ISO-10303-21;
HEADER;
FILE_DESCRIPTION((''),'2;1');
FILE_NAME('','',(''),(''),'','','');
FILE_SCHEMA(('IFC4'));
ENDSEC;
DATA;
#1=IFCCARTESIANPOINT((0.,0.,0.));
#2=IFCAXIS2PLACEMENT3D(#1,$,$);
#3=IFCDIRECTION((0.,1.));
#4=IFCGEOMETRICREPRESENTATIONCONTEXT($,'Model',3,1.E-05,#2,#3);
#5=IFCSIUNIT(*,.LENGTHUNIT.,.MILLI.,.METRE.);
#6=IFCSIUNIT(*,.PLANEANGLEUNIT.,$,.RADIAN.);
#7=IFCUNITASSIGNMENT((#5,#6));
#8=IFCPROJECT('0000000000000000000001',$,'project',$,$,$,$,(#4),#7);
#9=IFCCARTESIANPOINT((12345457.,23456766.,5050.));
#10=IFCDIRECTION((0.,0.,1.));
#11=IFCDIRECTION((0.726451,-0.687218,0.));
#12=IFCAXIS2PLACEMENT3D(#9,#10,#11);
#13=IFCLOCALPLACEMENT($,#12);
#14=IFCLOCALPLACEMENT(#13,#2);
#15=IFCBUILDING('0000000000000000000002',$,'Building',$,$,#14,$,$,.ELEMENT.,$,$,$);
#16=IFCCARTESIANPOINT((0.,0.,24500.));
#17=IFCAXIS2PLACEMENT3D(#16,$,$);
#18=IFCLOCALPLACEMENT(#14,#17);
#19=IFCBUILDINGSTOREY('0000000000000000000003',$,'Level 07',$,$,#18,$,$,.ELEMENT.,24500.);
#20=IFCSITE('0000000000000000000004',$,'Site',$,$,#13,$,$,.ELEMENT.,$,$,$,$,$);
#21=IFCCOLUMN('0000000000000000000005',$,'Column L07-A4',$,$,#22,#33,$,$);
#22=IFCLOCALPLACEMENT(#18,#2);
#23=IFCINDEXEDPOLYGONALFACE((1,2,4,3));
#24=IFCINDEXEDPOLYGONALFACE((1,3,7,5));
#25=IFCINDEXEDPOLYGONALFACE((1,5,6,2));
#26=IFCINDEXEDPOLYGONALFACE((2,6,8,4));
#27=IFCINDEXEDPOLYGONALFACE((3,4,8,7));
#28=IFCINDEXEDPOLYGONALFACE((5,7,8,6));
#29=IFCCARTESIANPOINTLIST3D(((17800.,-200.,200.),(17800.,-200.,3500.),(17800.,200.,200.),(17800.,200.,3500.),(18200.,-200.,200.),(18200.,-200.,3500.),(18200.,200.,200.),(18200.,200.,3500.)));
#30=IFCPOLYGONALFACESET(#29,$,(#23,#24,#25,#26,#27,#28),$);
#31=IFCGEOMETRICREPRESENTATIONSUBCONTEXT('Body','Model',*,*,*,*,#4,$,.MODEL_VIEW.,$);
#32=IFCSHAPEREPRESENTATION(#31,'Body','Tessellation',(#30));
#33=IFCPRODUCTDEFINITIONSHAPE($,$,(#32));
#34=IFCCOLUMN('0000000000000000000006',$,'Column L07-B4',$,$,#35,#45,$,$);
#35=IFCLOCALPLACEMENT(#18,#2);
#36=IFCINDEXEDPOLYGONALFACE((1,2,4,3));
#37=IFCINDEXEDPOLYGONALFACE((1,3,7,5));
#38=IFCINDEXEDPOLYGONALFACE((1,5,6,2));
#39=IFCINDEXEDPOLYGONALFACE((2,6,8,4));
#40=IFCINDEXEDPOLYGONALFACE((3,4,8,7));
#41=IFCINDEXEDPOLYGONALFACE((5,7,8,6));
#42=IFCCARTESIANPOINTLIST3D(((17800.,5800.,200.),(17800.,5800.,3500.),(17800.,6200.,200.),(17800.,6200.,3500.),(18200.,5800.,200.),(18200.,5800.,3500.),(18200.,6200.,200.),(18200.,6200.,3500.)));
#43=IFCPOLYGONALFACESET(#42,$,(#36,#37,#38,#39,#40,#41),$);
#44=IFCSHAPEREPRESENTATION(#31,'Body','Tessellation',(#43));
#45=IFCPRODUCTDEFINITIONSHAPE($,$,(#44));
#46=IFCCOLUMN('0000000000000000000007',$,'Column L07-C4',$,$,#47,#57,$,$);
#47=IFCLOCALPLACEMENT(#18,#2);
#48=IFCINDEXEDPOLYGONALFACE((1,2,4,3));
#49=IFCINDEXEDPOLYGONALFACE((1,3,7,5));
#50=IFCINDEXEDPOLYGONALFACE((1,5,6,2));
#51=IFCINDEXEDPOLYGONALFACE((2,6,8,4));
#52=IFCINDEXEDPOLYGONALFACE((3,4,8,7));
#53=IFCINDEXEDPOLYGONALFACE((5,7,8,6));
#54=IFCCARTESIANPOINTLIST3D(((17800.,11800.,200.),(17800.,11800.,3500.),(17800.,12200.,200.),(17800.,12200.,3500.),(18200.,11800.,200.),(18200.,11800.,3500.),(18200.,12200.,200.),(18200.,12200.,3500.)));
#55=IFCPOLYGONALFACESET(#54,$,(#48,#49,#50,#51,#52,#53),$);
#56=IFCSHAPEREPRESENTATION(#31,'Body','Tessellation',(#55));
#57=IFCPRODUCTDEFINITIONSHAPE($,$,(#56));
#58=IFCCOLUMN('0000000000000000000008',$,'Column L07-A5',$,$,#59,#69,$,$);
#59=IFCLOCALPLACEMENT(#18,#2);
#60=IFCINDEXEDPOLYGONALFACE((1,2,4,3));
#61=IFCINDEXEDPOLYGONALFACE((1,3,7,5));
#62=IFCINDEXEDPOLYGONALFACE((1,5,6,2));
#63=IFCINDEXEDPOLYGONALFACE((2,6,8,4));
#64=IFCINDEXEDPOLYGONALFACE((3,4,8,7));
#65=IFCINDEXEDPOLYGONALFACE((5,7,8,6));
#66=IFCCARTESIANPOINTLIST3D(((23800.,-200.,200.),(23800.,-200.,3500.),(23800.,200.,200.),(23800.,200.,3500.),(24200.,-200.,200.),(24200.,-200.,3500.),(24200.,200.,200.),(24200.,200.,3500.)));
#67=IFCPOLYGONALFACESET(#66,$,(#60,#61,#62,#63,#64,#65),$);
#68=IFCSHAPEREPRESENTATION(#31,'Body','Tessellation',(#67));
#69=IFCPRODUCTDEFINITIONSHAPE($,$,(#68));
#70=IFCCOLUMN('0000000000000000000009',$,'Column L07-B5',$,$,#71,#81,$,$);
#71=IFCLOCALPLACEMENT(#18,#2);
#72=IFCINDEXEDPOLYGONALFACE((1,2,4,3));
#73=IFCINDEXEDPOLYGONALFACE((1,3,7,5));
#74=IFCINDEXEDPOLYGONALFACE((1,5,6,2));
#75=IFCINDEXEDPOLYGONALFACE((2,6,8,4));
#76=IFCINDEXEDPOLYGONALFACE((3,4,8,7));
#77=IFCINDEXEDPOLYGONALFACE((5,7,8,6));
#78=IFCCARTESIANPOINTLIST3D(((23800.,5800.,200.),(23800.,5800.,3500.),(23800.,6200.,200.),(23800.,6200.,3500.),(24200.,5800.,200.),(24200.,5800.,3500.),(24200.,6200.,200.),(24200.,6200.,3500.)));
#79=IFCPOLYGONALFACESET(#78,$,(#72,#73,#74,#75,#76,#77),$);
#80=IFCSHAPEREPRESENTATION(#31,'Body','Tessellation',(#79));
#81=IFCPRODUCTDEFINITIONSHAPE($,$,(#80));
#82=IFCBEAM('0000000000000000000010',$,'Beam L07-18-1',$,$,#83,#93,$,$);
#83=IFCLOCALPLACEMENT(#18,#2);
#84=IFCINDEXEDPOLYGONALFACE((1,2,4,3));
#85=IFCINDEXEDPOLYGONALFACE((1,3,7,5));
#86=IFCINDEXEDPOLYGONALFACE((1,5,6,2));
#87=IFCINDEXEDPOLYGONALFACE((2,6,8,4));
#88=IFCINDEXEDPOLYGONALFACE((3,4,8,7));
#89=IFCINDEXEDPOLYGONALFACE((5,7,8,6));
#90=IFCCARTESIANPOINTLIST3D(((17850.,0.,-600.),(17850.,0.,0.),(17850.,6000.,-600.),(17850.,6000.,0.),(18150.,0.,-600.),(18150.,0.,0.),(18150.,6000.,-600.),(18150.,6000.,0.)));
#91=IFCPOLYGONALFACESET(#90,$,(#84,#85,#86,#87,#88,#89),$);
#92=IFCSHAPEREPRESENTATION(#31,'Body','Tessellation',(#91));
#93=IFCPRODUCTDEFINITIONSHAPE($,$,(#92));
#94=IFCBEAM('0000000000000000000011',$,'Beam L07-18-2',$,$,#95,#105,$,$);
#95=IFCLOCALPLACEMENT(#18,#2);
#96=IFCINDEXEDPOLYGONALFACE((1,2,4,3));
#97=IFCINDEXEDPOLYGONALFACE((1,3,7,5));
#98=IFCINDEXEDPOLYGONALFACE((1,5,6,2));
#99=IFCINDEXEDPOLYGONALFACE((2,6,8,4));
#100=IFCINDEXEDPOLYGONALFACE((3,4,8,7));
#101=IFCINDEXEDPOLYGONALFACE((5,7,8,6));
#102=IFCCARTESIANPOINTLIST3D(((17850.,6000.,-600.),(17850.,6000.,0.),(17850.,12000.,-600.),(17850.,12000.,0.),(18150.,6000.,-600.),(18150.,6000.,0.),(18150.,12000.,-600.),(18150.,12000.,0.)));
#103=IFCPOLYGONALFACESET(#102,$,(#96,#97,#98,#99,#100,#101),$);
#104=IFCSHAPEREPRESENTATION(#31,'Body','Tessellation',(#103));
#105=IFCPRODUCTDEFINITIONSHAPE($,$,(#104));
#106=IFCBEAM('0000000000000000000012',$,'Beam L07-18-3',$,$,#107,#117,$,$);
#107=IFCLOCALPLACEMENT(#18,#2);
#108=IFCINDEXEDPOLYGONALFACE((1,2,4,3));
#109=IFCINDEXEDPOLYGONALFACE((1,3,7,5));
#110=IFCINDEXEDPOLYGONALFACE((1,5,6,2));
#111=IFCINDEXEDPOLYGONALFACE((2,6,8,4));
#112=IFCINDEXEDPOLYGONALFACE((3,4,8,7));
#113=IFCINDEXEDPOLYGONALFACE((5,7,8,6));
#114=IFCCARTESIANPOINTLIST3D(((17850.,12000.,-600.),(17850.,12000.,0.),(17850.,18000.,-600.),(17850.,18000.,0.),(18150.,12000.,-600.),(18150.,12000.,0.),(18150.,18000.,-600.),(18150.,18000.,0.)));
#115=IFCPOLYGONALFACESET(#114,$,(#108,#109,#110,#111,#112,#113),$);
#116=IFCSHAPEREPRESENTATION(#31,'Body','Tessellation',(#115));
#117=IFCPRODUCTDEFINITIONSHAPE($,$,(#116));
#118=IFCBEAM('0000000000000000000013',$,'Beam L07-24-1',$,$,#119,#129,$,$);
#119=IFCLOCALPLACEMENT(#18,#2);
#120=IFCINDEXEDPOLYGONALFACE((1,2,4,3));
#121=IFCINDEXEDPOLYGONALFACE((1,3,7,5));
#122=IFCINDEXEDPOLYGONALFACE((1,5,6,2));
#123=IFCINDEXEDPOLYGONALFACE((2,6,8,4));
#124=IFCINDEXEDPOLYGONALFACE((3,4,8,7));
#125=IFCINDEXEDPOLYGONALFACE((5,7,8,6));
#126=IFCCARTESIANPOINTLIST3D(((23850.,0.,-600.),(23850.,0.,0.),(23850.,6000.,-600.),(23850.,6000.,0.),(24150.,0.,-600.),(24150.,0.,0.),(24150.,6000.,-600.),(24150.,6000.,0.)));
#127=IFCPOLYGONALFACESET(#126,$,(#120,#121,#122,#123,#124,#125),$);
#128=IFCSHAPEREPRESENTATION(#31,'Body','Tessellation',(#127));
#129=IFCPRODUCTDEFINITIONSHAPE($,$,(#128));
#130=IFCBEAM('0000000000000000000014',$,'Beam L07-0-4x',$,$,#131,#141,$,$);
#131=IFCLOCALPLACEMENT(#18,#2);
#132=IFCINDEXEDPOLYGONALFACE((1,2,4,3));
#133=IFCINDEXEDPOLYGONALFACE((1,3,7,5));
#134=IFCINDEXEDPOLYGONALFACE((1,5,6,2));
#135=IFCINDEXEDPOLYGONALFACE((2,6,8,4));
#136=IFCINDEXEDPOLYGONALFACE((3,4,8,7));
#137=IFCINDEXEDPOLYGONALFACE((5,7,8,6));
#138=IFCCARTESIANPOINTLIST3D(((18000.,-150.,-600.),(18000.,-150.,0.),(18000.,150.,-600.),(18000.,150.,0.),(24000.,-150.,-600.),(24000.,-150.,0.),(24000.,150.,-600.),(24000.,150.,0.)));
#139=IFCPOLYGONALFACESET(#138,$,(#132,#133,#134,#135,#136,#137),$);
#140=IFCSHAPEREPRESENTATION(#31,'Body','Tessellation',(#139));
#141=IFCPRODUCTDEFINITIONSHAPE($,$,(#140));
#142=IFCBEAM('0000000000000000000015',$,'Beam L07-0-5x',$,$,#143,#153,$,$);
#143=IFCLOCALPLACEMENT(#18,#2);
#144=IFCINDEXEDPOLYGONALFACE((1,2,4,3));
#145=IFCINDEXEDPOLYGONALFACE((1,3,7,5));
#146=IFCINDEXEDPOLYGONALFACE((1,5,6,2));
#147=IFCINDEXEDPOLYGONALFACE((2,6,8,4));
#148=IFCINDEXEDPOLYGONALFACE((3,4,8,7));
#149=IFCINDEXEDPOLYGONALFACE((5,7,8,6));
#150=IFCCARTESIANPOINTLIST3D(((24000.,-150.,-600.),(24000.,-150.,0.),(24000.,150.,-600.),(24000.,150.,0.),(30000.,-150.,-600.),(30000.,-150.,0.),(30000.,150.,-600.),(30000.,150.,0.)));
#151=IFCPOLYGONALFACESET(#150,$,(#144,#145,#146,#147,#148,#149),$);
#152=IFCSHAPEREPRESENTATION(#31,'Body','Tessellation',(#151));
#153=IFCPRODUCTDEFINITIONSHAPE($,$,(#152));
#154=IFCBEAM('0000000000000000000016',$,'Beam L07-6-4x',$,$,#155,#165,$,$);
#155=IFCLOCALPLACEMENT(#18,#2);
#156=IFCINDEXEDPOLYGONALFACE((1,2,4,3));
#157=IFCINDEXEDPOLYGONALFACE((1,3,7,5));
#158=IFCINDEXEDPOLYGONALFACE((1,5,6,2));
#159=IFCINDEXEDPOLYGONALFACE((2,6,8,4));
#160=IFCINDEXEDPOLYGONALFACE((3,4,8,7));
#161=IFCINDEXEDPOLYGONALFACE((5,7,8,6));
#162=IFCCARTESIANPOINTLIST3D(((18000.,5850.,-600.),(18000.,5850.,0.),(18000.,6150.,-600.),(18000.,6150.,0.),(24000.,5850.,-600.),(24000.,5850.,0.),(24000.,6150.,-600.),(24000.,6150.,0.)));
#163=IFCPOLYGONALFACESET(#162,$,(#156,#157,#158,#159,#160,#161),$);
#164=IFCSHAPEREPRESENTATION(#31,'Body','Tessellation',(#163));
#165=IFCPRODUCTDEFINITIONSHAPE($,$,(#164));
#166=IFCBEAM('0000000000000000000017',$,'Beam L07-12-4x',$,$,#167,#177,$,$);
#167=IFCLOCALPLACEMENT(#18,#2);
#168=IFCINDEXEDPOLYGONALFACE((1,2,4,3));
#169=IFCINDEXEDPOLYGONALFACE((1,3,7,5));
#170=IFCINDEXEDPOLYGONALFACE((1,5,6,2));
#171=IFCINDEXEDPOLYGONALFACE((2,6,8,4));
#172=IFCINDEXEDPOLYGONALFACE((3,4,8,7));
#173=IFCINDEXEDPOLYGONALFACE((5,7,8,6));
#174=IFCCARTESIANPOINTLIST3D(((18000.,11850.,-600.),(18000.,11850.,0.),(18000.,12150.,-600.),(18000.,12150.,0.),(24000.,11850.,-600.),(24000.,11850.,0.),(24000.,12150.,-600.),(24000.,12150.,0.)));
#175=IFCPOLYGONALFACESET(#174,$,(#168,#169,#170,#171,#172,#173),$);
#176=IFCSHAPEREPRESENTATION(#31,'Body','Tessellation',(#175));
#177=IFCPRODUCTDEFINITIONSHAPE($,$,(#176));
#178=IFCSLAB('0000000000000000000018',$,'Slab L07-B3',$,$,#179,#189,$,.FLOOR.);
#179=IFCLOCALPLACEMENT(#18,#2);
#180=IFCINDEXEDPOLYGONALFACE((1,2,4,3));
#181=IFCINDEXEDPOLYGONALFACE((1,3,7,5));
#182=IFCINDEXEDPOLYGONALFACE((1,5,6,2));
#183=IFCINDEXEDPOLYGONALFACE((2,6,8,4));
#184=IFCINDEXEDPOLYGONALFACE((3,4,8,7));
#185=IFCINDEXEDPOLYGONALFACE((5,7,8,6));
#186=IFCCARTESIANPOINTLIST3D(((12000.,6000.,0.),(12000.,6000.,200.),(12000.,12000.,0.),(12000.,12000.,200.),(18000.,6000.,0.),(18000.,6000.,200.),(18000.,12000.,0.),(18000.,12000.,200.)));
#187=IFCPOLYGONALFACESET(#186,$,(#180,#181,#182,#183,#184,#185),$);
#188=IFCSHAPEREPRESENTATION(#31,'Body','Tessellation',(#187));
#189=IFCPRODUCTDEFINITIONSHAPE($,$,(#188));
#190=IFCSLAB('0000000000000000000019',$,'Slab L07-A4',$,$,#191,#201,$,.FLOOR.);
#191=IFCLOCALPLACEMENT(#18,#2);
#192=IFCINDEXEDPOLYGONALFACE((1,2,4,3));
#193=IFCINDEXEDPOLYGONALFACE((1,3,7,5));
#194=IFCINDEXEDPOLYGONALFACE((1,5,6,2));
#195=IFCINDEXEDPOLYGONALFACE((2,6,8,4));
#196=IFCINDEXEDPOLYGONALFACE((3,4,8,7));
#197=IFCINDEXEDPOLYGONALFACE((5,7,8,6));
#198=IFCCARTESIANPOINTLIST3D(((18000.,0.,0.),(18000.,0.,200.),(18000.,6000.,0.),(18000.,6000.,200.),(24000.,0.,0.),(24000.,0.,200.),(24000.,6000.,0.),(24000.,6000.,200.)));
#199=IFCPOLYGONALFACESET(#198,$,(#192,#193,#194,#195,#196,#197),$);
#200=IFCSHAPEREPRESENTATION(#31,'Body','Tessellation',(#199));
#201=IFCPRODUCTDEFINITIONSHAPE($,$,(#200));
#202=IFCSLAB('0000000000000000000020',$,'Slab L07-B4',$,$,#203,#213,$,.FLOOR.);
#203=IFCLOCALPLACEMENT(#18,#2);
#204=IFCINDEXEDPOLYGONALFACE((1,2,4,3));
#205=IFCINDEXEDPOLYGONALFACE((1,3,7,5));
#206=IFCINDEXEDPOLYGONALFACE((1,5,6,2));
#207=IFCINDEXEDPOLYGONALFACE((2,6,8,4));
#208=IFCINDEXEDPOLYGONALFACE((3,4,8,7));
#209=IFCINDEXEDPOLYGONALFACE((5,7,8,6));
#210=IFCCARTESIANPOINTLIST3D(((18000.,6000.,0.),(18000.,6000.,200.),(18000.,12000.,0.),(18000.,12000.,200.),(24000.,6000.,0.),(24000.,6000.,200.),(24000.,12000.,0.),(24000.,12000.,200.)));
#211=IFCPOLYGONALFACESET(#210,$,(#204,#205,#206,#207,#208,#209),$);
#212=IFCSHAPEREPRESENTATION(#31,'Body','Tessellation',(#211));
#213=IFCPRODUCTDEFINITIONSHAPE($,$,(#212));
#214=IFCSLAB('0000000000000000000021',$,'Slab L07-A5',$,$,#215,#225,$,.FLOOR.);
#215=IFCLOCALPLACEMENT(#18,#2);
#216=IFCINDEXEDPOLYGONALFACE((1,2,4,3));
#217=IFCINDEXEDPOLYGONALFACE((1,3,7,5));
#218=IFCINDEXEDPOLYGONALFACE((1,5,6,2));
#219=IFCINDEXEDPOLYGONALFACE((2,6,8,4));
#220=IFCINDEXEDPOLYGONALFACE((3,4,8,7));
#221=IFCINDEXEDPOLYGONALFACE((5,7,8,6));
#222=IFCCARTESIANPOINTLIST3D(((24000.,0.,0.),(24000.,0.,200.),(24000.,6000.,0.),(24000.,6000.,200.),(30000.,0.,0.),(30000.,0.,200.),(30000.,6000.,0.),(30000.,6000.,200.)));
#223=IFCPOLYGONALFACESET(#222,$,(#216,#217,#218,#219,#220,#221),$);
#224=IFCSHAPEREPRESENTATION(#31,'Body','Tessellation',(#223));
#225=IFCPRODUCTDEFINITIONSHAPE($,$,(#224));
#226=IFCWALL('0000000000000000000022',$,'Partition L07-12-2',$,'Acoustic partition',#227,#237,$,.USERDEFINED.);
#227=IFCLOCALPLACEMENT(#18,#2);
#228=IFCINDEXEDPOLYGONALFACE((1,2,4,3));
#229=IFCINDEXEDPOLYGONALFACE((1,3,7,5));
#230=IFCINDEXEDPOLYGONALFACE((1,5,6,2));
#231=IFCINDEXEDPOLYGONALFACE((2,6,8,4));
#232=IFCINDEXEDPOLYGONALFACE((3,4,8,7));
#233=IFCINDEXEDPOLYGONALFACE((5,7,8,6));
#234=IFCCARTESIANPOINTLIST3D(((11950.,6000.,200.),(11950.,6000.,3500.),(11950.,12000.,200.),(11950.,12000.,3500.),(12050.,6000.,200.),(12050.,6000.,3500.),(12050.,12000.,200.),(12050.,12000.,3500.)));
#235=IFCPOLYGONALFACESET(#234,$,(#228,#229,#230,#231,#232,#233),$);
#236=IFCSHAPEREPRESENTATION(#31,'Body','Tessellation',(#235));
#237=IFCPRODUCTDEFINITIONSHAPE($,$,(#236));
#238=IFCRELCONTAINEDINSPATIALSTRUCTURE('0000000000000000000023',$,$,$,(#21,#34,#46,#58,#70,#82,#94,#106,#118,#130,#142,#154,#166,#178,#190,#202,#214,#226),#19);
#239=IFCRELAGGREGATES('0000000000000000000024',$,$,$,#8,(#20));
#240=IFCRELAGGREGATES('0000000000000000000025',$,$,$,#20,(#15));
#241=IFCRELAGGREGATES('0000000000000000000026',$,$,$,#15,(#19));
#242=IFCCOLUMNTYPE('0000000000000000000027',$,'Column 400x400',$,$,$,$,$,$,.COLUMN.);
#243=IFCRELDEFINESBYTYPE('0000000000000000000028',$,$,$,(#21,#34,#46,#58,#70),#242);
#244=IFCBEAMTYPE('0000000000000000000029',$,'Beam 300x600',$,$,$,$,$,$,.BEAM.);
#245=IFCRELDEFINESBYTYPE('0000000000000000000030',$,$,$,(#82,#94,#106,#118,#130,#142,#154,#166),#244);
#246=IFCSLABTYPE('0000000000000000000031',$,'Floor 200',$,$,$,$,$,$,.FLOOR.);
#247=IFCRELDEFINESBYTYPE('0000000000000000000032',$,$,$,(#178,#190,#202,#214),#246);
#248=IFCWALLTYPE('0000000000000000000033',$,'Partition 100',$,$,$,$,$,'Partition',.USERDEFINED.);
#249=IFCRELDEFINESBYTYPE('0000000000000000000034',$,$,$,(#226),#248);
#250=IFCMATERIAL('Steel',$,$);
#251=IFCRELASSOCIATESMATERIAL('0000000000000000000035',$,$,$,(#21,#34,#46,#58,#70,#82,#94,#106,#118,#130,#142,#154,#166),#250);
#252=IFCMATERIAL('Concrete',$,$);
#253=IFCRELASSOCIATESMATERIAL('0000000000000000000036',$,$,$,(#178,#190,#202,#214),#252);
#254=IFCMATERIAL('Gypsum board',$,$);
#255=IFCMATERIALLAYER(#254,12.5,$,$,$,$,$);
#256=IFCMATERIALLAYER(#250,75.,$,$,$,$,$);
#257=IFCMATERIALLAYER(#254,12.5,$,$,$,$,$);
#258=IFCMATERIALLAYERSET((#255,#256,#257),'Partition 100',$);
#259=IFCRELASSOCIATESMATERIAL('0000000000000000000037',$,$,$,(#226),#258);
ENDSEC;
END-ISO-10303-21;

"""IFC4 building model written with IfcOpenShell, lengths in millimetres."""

from ifc_helpers import new_model, si_unit, direction, frame, origin, place, context, subcontext, project, spatial, rectangle, extrude, material, layer, layer_set, layer_usage, type_object, element, save


model = new_model("IFC4")

# Units and contexts
model_context = context("Model", 3, precision=1e-05, world=origin(), true_north=direction((0.0, 1.0)))
body_context = subcontext(model_context, "Body", "Model", "MODEL_VIEW")
ifc_project = project(units=[si_unit("LENGTHUNIT", "METRE", prefix="MILLI"), si_unit("PLANEANGLEUNIT", "RADIAN")], contexts=[model_context])

# Site, building, storey
site_placement = place(None, frame((12345457.0, 23456766.0, 5050.0), z_axis=(0.0, 0.0, 1.0), x_axis=(0.726451, -0.687218, 0.0)))
site = spatial("IfcSite", under=ifc_project, at=site_placement, Name="Site", CompositionType="ELEMENT")
building_placement = place(site_placement, origin())
building = spatial("IfcBuilding", under=site, at=building_placement, Name="Building", CompositionType="ELEMENT")
storey_placement = place(building_placement, frame((0.0, 0.0, 24500.0)))
storey = spatial("IfcBuildingStorey", under=building, at=storey_placement, Name="Level 07", CompositionType="ELEMENT", Elevation=24500.0)

# Columns
ifc_material_1 = material(Name="Steel")
column_type = type_object("IfcColumnType", Name="Column 400x400", PredefinedType="COLUMN")
for number, where, name in (
    (1, (17800.0, -200.0, 200.0), "Column L07-A4"),
    (2, (17800.0, 5800.0, 200.0), "Column L07-B4"),
    (3, (17800.0, 11800.0, 200.0), "Column L07-C4"),
    (4, (23800.0, -200.0, 200.0), "Column L07-A5"),
    (5, (23800.0, 5800.0, 200.0), "Column L07-B5"),
):
    element("IfcColumn", number, at=place(storey_placement, frame(where)), inside=storey, type_object=column_type, material=ifc_material_1, Name=name, context=body_context, shape_type="SweptSolid", body=[
        extrude(rectangle(XDim=400.0, YDim=400.0), frame((200.0, 200.0, 0.0)), (0.0, 0.0, 1.0), 3300.0),
    ])

# Beams
beam_type = type_object("IfcBeamType", Name="Beam 300x600", PredefinedType="BEAM")
for number, where, name in (
    (6, (17850.0, 0.0, -600.0), "Beam L07-18-1"),
    (7, (17850.0, 6000.0, -600.0), "Beam L07-18-2"),
    (8, (17850.0, 12000.0, -600.0), "Beam L07-18-3"),
    (9, (23850.0, 0.0, -600.0), "Beam L07-24-1"),
):
    element("IfcBeam", number, at=place(storey_placement, frame(where)), inside=storey, type_object=beam_type, material=ifc_material_1, Name=name, context=body_context, shape_type="SweptSolid", body=[
        extrude(rectangle(XDim=300.0, YDim=6000.0), frame((150.0, 3000.0, 0.0)), (0.0, 0.0, 1.0), 600.0),
    ])
for number, where, name in (
    (10, (18000.0, -150.0, -600.0), "Beam L07-0-4x"),
    (11, (24000.0, -150.0, -600.0), "Beam L07-0-5x"),
    (12, (18000.0, 5850.0, -600.0), "Beam L07-6-4x"),
    (13, (18000.0, 11850.0, -600.0), "Beam L07-12-4x"),
):
    element("IfcBeam", number, at=place(storey_placement, frame(where)), inside=storey, type_object=beam_type, material=ifc_material_1, Name=name, context=body_context, shape_type="SweptSolid", body=[
        extrude(rectangle(XDim=6000.0, YDim=300.0), frame((3000.0, 150.0, 0.0)), (0.0, 0.0, 1.0), 600.0),
    ])

# Slabs
ifc_material_2 = material(Name="Concrete")
slab_type = type_object("IfcSlabType", Name="Floor 200", PredefinedType="FLOOR")
for number, where, name in (
    (14, (12000.0, 6000.0, 0.0), "Slab L07-B3"),
    (15, (18000.0, 0.0, 0.0), "Slab L07-A4"),
    (16, (18000.0, 6000.0, 0.0), "Slab L07-B4"),
    (17, (24000.0, 0.0, 0.0), "Slab L07-A5"),
):
    element("IfcSlab", number, at=place(storey_placement, frame(where)), inside=storey, type_object=slab_type, material=ifc_material_2, Name=name, PredefinedType="FLOOR", context=body_context, shape_type="SweptSolid", body=[
        extrude(rectangle(XDim=6000.0, YDim=6000.0), frame((3000.0, 3000.0, 0.0)), (0.0, 0.0, 1.0), 200.0),
    ])

# Wall
ifc_material_3 = material(Name="Gypsum board")
ifc_layer_1 = layer(ifc_material_3, 12.5)
ifc_layer_2 = layer(ifc_material_1, 75.0)
ifc_layer_3 = layer(ifc_material_3, 12.5)
ifc_layer_set = layer_set([ifc_layer_1, ifc_layer_2, ifc_layer_3], Name="Partition 100")
ifc_layer_usage = layer_usage(ifc_layer_set, "AXIS2", "POSITIVE", 0.0)
wall_type = type_object("IfcWallType", Name="Partition 100", ElementType="Partition", PredefinedType="USERDEFINED")
for number, where, name in (
    (18, (11950.0, 6000.0, 200.0), "Partition L07-12-2"),
):
    element("IfcWall", number, at=place(storey_placement, frame(where)), inside=storey, type_object=wall_type, material=ifc_layer_usage, Name=name, ObjectType="Acoustic partition", PredefinedType="USERDEFINED", context=body_context, shape_type="SweptSolid", body=[
        extrude(rectangle(XDim=100.0, YDim=6000.0), frame((50.0, 3000.0, 0.0)), (0.0, 0.0, 1.0), 3300.0),
    ])

save(model, "model.ifc")
